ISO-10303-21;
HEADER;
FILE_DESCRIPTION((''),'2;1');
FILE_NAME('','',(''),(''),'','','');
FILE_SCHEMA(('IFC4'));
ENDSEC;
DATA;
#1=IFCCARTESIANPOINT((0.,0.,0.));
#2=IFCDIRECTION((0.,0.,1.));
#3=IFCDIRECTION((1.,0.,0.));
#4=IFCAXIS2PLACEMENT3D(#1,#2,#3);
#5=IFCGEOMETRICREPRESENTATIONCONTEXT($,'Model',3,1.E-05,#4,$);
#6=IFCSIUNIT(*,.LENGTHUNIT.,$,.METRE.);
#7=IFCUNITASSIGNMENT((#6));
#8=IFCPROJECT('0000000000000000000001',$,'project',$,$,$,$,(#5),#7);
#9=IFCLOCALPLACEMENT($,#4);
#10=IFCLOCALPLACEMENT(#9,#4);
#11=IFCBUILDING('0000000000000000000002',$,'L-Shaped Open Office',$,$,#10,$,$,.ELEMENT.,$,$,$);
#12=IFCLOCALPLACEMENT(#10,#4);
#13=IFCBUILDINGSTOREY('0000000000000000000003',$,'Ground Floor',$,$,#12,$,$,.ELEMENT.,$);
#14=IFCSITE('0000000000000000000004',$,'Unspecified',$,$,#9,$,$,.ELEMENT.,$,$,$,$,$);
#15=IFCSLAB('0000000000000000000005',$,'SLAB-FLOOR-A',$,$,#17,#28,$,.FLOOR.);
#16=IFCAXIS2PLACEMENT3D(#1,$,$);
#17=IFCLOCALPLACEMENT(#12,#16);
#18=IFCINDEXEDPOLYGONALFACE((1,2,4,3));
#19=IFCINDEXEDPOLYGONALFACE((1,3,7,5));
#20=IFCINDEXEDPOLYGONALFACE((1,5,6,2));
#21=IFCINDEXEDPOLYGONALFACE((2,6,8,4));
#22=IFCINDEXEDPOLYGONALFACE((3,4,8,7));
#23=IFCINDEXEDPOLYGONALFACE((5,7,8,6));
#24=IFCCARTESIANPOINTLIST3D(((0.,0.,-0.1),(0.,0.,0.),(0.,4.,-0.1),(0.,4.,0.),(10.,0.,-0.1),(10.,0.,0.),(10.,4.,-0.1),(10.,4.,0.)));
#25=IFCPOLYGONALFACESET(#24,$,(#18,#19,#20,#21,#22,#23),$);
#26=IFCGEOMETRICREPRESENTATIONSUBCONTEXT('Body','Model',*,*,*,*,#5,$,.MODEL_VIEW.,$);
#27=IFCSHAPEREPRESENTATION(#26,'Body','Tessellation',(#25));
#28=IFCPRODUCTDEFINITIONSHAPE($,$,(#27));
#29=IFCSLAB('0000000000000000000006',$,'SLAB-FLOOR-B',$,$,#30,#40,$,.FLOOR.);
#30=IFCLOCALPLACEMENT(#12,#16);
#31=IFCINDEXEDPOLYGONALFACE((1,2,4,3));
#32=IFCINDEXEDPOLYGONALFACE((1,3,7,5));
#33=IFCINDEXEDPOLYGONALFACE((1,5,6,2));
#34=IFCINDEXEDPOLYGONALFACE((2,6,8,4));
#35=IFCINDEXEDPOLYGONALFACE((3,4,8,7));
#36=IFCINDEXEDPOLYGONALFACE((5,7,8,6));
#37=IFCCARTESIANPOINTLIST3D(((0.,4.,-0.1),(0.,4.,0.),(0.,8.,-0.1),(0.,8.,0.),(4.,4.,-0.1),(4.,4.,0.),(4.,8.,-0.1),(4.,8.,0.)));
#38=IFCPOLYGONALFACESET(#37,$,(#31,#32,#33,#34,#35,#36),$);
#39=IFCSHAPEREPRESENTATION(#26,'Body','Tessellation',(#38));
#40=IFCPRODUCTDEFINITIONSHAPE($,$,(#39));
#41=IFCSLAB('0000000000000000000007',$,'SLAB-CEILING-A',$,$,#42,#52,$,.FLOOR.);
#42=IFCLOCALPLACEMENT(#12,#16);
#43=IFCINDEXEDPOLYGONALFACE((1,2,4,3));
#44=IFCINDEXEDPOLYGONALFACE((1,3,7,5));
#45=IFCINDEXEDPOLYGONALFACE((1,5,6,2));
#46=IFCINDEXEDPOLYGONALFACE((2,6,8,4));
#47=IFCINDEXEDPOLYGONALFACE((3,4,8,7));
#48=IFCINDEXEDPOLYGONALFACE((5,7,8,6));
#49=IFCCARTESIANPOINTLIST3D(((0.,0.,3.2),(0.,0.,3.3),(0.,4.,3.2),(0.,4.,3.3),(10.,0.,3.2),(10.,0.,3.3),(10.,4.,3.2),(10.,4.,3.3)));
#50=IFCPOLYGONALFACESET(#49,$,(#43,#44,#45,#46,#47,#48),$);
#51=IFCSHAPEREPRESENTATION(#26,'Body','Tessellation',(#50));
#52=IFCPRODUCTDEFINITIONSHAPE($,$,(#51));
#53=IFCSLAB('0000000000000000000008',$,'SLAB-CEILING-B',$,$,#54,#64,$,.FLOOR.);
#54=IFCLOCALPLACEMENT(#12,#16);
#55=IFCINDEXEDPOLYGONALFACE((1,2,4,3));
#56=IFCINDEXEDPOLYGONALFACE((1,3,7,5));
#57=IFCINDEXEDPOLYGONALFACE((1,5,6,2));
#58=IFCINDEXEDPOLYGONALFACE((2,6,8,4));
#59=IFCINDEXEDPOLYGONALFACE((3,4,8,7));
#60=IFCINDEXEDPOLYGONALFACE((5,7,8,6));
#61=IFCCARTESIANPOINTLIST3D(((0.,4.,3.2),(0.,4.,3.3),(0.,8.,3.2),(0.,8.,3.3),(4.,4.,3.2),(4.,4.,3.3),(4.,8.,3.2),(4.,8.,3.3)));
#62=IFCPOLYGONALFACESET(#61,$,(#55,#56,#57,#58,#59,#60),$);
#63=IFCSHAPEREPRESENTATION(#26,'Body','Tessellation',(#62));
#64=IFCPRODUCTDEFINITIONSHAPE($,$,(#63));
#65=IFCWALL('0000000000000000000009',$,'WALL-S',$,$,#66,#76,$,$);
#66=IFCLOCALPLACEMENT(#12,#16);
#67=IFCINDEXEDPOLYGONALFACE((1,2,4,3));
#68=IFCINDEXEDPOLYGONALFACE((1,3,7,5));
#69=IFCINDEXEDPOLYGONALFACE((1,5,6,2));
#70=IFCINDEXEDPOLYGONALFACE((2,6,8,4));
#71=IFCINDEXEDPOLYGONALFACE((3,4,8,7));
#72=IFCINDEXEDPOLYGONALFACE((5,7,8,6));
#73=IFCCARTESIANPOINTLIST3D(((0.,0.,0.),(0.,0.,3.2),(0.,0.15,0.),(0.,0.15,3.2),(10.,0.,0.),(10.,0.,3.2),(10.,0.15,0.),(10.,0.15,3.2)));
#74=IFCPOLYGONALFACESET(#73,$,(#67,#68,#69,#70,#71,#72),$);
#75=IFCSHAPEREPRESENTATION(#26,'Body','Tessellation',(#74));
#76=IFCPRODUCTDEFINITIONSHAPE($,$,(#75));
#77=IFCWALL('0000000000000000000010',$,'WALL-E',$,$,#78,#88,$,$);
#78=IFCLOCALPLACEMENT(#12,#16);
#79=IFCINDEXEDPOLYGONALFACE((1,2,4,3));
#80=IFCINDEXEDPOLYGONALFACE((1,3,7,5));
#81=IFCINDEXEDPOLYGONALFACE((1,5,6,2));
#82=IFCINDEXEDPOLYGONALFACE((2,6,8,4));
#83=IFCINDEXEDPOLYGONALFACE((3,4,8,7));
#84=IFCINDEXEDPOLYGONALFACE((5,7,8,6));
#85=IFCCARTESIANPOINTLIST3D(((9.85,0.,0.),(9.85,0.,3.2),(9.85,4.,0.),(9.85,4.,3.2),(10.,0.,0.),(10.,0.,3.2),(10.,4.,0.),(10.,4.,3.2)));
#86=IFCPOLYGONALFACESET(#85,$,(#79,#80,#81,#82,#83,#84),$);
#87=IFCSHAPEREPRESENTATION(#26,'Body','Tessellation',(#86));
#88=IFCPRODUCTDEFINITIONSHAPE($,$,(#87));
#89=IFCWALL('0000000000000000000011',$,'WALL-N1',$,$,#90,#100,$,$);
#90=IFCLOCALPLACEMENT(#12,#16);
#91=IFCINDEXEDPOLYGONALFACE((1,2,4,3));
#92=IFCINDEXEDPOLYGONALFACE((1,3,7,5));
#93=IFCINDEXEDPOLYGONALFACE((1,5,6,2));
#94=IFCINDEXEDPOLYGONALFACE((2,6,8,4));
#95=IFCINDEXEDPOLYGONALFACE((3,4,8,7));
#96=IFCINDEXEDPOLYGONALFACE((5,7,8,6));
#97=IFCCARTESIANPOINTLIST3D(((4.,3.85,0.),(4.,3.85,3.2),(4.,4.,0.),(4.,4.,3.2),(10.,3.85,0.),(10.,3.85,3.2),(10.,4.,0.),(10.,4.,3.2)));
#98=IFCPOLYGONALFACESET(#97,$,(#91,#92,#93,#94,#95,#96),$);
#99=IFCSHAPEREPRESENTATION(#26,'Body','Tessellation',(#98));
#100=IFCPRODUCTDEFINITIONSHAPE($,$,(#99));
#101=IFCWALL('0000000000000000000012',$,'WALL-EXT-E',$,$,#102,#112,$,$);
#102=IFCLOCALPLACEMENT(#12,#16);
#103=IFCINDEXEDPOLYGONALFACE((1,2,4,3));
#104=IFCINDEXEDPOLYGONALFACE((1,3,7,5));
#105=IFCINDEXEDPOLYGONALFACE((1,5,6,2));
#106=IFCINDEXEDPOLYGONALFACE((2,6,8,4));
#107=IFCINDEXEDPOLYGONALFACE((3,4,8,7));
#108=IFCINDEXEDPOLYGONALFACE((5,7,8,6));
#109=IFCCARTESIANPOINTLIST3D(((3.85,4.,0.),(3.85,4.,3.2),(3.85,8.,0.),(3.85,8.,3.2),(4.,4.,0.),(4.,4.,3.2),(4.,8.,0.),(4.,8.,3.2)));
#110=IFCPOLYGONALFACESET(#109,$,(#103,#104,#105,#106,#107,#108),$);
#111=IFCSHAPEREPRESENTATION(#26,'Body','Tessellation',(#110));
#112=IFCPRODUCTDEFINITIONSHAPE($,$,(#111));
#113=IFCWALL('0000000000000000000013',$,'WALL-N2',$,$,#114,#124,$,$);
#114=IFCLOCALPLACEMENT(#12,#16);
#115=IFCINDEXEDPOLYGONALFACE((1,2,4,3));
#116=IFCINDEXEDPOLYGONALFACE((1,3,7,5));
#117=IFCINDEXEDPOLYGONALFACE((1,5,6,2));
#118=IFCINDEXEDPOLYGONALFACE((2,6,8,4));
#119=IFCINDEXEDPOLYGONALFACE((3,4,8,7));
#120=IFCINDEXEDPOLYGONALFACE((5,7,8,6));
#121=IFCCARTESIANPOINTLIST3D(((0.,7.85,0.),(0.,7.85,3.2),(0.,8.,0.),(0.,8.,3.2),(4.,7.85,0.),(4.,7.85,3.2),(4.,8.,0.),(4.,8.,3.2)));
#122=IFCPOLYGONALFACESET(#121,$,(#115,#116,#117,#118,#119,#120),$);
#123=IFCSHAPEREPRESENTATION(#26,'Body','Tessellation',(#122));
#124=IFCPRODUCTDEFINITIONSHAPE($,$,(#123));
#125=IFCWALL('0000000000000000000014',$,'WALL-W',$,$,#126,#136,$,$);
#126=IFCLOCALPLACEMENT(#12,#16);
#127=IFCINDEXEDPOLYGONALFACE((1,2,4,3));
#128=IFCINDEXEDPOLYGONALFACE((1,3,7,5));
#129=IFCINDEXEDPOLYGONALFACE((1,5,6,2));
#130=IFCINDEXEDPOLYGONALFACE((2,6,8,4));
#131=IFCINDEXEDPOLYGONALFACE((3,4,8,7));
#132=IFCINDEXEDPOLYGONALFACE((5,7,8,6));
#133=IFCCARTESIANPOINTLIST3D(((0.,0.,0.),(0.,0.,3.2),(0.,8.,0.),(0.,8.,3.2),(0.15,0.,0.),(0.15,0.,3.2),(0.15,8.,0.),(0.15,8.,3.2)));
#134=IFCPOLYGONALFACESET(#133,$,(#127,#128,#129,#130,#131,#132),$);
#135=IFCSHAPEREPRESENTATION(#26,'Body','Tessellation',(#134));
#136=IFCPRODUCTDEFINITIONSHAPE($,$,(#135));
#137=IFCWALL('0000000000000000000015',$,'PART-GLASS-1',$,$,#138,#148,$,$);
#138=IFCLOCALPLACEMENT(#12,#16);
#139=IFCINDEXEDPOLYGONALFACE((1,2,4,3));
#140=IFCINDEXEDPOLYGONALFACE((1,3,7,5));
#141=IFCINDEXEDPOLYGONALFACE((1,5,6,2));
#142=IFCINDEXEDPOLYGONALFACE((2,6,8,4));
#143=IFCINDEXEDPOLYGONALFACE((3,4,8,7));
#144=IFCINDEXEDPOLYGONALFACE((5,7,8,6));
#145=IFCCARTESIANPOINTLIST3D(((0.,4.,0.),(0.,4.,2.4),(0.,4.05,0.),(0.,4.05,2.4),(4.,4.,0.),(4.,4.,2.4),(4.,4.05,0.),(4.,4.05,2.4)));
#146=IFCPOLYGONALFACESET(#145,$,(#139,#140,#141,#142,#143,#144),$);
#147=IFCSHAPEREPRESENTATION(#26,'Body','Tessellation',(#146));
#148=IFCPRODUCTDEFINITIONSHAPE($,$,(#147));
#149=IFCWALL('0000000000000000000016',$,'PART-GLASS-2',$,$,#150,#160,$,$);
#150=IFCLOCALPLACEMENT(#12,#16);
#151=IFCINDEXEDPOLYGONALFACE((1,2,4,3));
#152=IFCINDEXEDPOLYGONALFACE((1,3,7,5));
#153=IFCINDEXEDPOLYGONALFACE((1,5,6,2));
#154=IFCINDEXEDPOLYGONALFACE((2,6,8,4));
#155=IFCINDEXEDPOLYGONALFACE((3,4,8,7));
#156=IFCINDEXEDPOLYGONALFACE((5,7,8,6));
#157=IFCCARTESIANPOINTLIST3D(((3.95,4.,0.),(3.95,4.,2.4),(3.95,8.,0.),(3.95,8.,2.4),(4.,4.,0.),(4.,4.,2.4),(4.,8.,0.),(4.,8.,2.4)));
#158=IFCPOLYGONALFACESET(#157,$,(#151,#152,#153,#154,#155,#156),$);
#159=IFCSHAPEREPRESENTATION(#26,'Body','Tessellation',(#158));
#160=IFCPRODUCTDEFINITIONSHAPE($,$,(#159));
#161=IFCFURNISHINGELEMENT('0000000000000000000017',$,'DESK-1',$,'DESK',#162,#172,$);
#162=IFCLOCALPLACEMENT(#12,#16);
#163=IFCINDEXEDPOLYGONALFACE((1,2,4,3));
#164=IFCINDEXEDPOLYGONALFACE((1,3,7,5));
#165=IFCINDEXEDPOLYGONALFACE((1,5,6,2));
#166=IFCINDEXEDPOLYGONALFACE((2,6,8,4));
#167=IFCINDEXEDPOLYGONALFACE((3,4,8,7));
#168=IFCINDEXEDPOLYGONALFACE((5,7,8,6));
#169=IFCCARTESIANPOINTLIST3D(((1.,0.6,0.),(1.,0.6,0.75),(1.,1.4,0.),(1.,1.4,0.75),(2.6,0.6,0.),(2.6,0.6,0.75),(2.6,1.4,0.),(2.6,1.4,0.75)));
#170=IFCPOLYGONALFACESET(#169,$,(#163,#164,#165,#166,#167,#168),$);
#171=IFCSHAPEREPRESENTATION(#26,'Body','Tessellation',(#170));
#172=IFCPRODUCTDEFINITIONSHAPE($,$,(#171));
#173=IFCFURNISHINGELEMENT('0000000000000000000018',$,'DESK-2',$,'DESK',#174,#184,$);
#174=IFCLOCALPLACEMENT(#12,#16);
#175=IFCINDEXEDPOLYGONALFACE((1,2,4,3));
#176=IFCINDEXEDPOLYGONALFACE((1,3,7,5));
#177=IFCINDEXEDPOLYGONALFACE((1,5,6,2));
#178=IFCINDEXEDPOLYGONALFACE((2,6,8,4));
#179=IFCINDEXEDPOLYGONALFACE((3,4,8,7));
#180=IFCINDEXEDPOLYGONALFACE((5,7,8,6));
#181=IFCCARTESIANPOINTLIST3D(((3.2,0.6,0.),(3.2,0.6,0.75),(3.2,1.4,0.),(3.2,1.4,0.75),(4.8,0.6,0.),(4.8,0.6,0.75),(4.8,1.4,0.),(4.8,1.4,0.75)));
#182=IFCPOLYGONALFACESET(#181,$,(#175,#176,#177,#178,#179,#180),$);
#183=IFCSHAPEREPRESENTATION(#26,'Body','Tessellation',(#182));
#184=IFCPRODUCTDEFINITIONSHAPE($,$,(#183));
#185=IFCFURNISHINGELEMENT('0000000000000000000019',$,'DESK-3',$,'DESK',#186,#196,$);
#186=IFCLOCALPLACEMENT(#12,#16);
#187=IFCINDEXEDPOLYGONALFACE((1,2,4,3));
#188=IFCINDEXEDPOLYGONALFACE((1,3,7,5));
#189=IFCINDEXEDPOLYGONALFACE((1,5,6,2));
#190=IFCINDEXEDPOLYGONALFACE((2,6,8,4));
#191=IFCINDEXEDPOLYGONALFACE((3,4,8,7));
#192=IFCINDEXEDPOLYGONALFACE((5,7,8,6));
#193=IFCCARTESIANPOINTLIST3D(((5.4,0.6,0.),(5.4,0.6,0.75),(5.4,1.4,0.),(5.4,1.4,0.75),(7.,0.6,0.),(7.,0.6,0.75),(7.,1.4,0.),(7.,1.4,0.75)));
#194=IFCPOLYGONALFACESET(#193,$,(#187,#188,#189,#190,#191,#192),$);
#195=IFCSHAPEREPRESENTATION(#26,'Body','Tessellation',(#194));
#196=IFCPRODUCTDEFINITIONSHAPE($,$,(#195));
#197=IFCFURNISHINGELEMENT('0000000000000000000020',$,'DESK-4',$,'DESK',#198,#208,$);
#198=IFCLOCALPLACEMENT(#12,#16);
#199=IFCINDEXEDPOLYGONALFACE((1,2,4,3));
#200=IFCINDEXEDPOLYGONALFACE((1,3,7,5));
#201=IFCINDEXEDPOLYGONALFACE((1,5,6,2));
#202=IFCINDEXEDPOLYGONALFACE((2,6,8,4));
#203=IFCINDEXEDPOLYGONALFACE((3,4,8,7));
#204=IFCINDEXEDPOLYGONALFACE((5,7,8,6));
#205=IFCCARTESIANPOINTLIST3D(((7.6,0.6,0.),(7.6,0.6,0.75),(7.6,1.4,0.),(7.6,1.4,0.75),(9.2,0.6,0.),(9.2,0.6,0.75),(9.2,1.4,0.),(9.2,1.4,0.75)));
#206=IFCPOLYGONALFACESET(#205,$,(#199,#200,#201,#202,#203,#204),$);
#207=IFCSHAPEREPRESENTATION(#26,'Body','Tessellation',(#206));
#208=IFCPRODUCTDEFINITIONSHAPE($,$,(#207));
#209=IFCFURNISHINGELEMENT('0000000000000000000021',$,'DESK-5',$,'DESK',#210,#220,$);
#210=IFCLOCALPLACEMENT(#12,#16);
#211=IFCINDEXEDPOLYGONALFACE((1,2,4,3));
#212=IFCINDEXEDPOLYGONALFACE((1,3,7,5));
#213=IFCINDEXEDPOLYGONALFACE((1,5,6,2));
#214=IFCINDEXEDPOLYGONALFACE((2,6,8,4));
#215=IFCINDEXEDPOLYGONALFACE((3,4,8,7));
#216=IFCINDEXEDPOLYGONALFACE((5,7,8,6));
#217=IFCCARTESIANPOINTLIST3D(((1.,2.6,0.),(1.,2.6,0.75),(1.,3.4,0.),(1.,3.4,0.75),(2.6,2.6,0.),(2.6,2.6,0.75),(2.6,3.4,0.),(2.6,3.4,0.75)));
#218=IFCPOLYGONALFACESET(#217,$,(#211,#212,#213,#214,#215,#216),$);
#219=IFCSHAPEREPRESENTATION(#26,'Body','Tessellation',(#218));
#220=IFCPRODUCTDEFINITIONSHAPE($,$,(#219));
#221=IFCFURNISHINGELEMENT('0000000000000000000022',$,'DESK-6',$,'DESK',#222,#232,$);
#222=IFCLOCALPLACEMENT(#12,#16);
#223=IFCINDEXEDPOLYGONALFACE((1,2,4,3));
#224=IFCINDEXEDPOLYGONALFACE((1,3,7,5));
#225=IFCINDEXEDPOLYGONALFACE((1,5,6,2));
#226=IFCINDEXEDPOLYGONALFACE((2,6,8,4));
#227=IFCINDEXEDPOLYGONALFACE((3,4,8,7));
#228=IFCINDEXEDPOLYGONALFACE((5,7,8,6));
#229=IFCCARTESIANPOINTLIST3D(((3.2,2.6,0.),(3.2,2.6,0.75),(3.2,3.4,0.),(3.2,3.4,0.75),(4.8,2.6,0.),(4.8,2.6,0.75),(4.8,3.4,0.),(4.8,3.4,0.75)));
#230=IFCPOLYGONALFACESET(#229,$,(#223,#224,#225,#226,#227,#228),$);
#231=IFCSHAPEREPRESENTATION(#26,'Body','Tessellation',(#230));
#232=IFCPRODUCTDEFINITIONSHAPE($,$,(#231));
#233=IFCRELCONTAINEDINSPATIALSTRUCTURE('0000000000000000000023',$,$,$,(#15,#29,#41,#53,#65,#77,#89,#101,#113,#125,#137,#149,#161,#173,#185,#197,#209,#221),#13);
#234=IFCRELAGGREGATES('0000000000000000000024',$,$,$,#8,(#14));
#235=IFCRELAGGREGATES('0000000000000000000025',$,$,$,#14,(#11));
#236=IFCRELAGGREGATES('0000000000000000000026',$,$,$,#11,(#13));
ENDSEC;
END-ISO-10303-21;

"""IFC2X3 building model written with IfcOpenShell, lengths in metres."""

from ifc_helpers import new_model, si_unit, frame, frame_2d, origin, origin_with_axes, place, context, subcontext, project, spatial, rectangle, extrude, element, save


model = new_model("IFC2X3")

# Units and contexts
model_context = context("Model", 3, precision=1e-05, world=origin_with_axes())
body_context = subcontext(model_context, "Body", "Model", "MODEL_VIEW")
ifc_project = project(units=[si_unit("LENGTHUNIT", "METRE")], contexts=[model_context])

# Site, building, storey
site_placement = place(None, origin_with_axes())
site = spatial("IfcSite", under=ifc_project, at=site_placement, Name="Unspecified", CompositionType="ELEMENT")
building_placement = place(site_placement, origin_with_axes())
building = spatial("IfcBuilding", under=site, at=building_placement, Name="L-Shaped Open Office", CompositionType="ELEMENT")
storey_placement = place(building_placement, origin_with_axes())
storey = spatial("IfcBuildingStorey", under=building, at=storey_placement, Name="Ground Floor", CompositionType="ELEMENT")

# Slabs
slab_1_placement = place(storey_placement, frame((0.0, 0.0, -0.1), z_axis=(0.0, 0.0, 1.0), x_axis=(1.0, 0.0, 0.0)))
element("IfcSlab", 1, at=slab_1_placement, inside=storey, Name="SLAB-FLOOR-A", PredefinedType="FLOOR", context=body_context, shape_type="SweptSolid", body=[
    extrude(rectangle(XDim=10.0, YDim=4.0, at=frame_2d((5.0, 2.0))), origin(), (0.0, 0.0, 1.0), 0.1),
])
slab_2_placement = place(storey_placement, frame((0.0, 4.0, -0.1), z_axis=(0.0, 0.0, 1.0), x_axis=(1.0, 0.0, 0.0)))
element("IfcSlab", 2, at=slab_2_placement, inside=storey, Name="SLAB-FLOOR-B", PredefinedType="FLOOR", context=body_context, shape_type="SweptSolid", body=[
    extrude(rectangle(XDim=4.0, YDim=4.0, at=frame_2d((2.0, 2.0))), origin(), (0.0, 0.0, 1.0), 0.1),
])
slab_3_placement = place(storey_placement, frame((0.0, 0.0, 3.2), z_axis=(0.0, 0.0, 1.0), x_axis=(1.0, 0.0, 0.0)))
element("IfcSlab", 3, at=slab_3_placement, inside=storey, Name="SLAB-CEILING-A", PredefinedType="FLOOR", context=body_context, shape_type="SweptSolid", body=[
    extrude(rectangle(XDim=10.0, YDim=4.0, at=frame_2d((5.0, 2.0))), origin(), (0.0, 0.0, 1.0), 0.1),
])
slab_4_placement = place(storey_placement, frame((0.0, 4.0, 3.2), z_axis=(0.0, 0.0, 1.0), x_axis=(1.0, 0.0, 0.0)))
element("IfcSlab", 4, at=slab_4_placement, inside=storey, Name="SLAB-CEILING-B", PredefinedType="FLOOR", context=body_context, shape_type="SweptSolid", body=[
    extrude(rectangle(XDim=4.0, YDim=4.0, at=frame_2d((2.0, 2.0))), origin(), (0.0, 0.0, 1.0), 0.1),
])

# Walls
wall_1_placement = place(storey_placement, origin_with_axes())
element("IfcWall", 5, at=wall_1_placement, inside=storey, Name="WALL-S", context=body_context, shape_type="SweptSolid", body=[
    extrude(rectangle(XDim=10.0, YDim=0.15, at=frame_2d((5.0, 0.075))), origin(), (0.0, 0.0, 1.0), 3.2),
])
wall_2_placement = place(storey_placement, frame((10.0, 0.0, 0.0), z_axis=(0.0, 0.0, 1.0), x_axis=(0.0, 1.0, 0.0)))
element("IfcWall", 6, at=wall_2_placement, inside=storey, Name="WALL-E", context=body_context, shape_type="SweptSolid", body=[
    extrude(rectangle(XDim=4.0, YDim=0.15, at=frame_2d((2.0, 0.075))), origin(), (0.0, 0.0, 1.0), 3.2),
])
wall_3_placement = place(storey_placement, frame((10.0, 4.0, 0.0), z_axis=(0.0, 0.0, 1.0), x_axis=(-1.0, 0.0, 0.0)))
element("IfcWall", 7, at=wall_3_placement, inside=storey, Name="WALL-N1", context=body_context, shape_type="SweptSolid", body=[
    extrude(rectangle(XDim=6.0, YDim=0.15, at=frame_2d((3.0, 0.075))), origin(), (0.0, 0.0, 1.0), 3.2),
])
for number, where, z_axis, x_axis, name in (
    (8, (4.0, 4.0, 0.0), (0.0, 0.0, 1.0), (0.0, 1.0, 0.0), "WALL-EXT-E"),
    (9, (4.0, 8.0, 0.0), (0.0, 0.0, 1.0), (-1.0, 0.0, 0.0), "WALL-N2"),
):
    element("IfcWall", number, at=place(storey_placement, frame(where, z_axis=z_axis, x_axis=x_axis)), inside=storey, Name=name, context=body_context, shape_type="SweptSolid", body=[
        extrude(rectangle(XDim=4.0, YDim=0.15, at=frame_2d((2.0, 0.075))), origin(), (0.0, 0.0, 1.0), 3.2),
    ])
wall_4_placement = place(storey_placement, frame((0.0, 8.0, 0.0), z_axis=(0.0, 0.0, 1.0), x_axis=(0.0, -1.0, 0.0)))
element("IfcWall", 10, at=wall_4_placement, inside=storey, Name="WALL-W", context=body_context, shape_type="SweptSolid", body=[
    extrude(rectangle(XDim=8.0, YDim=0.15, at=frame_2d((4.0, 0.075))), origin(), (0.0, 0.0, 1.0), 3.2),
])
for number, where, z_axis, x_axis, name in (
    (11, (0.0, 4.0, 0.0), (0.0, 0.0, 1.0), (1.0, 0.0, 0.0), "PART-GLASS-1"),
    (12, (4.0, 4.0, 0.0), (0.0, 0.0, 1.0), (0.0, 1.0, 0.0), "PART-GLASS-2"),
):
    element("IfcWall", number, at=place(storey_placement, frame(where, z_axis=z_axis, x_axis=x_axis)), inside=storey, Name=name, context=body_context, shape_type="SweptSolid", body=[
        extrude(rectangle(XDim=4.0, YDim=0.05, at=frame_2d((2.0, 0.025))), origin(), (0.0, 0.0, 1.0), 2.4),
    ])

# Furnishing elements
for number, where, z_axis, x_axis, name in (
    (13, (1.0, 0.6, 0.0), (0.0, 0.0, 1.0), (1.0, 0.0, 0.0), "DESK-1"),
    (14, (3.2, 0.6, 0.0), (0.0, 0.0, 1.0), (1.0, 0.0, 0.0), "DESK-2"),
    (15, (5.4, 0.6, 0.0), (0.0, 0.0, 1.0), (1.0, 0.0, 0.0), "DESK-3"),
    (16, (7.6, 0.6, 0.0), (0.0, 0.0, 1.0), (1.0, 0.0, 0.0), "DESK-4"),
    (17, (1.0, 2.6, 0.0), (0.0, 0.0, 1.0), (1.0, 0.0, 0.0), "DESK-5"),
    (18, (3.2, 2.6, 0.0), (0.0, 0.0, 1.0), (1.0, 0.0, 0.0), "DESK-6"),
):
    element("IfcFurnishingElement", number, at=place(storey_placement, frame(where, z_axis=z_axis, x_axis=x_axis)), inside=storey, Name=name, ObjectType="DESK", context=body_context, shape_type="SweptSolid", body=[
        extrude(rectangle(XDim=1.6, YDim=0.8, at=frame_2d((0.8, 0.4))), origin(), (0.0, 0.0, 1.0), 0.75),
    ])

save(model, "model.ifc")
